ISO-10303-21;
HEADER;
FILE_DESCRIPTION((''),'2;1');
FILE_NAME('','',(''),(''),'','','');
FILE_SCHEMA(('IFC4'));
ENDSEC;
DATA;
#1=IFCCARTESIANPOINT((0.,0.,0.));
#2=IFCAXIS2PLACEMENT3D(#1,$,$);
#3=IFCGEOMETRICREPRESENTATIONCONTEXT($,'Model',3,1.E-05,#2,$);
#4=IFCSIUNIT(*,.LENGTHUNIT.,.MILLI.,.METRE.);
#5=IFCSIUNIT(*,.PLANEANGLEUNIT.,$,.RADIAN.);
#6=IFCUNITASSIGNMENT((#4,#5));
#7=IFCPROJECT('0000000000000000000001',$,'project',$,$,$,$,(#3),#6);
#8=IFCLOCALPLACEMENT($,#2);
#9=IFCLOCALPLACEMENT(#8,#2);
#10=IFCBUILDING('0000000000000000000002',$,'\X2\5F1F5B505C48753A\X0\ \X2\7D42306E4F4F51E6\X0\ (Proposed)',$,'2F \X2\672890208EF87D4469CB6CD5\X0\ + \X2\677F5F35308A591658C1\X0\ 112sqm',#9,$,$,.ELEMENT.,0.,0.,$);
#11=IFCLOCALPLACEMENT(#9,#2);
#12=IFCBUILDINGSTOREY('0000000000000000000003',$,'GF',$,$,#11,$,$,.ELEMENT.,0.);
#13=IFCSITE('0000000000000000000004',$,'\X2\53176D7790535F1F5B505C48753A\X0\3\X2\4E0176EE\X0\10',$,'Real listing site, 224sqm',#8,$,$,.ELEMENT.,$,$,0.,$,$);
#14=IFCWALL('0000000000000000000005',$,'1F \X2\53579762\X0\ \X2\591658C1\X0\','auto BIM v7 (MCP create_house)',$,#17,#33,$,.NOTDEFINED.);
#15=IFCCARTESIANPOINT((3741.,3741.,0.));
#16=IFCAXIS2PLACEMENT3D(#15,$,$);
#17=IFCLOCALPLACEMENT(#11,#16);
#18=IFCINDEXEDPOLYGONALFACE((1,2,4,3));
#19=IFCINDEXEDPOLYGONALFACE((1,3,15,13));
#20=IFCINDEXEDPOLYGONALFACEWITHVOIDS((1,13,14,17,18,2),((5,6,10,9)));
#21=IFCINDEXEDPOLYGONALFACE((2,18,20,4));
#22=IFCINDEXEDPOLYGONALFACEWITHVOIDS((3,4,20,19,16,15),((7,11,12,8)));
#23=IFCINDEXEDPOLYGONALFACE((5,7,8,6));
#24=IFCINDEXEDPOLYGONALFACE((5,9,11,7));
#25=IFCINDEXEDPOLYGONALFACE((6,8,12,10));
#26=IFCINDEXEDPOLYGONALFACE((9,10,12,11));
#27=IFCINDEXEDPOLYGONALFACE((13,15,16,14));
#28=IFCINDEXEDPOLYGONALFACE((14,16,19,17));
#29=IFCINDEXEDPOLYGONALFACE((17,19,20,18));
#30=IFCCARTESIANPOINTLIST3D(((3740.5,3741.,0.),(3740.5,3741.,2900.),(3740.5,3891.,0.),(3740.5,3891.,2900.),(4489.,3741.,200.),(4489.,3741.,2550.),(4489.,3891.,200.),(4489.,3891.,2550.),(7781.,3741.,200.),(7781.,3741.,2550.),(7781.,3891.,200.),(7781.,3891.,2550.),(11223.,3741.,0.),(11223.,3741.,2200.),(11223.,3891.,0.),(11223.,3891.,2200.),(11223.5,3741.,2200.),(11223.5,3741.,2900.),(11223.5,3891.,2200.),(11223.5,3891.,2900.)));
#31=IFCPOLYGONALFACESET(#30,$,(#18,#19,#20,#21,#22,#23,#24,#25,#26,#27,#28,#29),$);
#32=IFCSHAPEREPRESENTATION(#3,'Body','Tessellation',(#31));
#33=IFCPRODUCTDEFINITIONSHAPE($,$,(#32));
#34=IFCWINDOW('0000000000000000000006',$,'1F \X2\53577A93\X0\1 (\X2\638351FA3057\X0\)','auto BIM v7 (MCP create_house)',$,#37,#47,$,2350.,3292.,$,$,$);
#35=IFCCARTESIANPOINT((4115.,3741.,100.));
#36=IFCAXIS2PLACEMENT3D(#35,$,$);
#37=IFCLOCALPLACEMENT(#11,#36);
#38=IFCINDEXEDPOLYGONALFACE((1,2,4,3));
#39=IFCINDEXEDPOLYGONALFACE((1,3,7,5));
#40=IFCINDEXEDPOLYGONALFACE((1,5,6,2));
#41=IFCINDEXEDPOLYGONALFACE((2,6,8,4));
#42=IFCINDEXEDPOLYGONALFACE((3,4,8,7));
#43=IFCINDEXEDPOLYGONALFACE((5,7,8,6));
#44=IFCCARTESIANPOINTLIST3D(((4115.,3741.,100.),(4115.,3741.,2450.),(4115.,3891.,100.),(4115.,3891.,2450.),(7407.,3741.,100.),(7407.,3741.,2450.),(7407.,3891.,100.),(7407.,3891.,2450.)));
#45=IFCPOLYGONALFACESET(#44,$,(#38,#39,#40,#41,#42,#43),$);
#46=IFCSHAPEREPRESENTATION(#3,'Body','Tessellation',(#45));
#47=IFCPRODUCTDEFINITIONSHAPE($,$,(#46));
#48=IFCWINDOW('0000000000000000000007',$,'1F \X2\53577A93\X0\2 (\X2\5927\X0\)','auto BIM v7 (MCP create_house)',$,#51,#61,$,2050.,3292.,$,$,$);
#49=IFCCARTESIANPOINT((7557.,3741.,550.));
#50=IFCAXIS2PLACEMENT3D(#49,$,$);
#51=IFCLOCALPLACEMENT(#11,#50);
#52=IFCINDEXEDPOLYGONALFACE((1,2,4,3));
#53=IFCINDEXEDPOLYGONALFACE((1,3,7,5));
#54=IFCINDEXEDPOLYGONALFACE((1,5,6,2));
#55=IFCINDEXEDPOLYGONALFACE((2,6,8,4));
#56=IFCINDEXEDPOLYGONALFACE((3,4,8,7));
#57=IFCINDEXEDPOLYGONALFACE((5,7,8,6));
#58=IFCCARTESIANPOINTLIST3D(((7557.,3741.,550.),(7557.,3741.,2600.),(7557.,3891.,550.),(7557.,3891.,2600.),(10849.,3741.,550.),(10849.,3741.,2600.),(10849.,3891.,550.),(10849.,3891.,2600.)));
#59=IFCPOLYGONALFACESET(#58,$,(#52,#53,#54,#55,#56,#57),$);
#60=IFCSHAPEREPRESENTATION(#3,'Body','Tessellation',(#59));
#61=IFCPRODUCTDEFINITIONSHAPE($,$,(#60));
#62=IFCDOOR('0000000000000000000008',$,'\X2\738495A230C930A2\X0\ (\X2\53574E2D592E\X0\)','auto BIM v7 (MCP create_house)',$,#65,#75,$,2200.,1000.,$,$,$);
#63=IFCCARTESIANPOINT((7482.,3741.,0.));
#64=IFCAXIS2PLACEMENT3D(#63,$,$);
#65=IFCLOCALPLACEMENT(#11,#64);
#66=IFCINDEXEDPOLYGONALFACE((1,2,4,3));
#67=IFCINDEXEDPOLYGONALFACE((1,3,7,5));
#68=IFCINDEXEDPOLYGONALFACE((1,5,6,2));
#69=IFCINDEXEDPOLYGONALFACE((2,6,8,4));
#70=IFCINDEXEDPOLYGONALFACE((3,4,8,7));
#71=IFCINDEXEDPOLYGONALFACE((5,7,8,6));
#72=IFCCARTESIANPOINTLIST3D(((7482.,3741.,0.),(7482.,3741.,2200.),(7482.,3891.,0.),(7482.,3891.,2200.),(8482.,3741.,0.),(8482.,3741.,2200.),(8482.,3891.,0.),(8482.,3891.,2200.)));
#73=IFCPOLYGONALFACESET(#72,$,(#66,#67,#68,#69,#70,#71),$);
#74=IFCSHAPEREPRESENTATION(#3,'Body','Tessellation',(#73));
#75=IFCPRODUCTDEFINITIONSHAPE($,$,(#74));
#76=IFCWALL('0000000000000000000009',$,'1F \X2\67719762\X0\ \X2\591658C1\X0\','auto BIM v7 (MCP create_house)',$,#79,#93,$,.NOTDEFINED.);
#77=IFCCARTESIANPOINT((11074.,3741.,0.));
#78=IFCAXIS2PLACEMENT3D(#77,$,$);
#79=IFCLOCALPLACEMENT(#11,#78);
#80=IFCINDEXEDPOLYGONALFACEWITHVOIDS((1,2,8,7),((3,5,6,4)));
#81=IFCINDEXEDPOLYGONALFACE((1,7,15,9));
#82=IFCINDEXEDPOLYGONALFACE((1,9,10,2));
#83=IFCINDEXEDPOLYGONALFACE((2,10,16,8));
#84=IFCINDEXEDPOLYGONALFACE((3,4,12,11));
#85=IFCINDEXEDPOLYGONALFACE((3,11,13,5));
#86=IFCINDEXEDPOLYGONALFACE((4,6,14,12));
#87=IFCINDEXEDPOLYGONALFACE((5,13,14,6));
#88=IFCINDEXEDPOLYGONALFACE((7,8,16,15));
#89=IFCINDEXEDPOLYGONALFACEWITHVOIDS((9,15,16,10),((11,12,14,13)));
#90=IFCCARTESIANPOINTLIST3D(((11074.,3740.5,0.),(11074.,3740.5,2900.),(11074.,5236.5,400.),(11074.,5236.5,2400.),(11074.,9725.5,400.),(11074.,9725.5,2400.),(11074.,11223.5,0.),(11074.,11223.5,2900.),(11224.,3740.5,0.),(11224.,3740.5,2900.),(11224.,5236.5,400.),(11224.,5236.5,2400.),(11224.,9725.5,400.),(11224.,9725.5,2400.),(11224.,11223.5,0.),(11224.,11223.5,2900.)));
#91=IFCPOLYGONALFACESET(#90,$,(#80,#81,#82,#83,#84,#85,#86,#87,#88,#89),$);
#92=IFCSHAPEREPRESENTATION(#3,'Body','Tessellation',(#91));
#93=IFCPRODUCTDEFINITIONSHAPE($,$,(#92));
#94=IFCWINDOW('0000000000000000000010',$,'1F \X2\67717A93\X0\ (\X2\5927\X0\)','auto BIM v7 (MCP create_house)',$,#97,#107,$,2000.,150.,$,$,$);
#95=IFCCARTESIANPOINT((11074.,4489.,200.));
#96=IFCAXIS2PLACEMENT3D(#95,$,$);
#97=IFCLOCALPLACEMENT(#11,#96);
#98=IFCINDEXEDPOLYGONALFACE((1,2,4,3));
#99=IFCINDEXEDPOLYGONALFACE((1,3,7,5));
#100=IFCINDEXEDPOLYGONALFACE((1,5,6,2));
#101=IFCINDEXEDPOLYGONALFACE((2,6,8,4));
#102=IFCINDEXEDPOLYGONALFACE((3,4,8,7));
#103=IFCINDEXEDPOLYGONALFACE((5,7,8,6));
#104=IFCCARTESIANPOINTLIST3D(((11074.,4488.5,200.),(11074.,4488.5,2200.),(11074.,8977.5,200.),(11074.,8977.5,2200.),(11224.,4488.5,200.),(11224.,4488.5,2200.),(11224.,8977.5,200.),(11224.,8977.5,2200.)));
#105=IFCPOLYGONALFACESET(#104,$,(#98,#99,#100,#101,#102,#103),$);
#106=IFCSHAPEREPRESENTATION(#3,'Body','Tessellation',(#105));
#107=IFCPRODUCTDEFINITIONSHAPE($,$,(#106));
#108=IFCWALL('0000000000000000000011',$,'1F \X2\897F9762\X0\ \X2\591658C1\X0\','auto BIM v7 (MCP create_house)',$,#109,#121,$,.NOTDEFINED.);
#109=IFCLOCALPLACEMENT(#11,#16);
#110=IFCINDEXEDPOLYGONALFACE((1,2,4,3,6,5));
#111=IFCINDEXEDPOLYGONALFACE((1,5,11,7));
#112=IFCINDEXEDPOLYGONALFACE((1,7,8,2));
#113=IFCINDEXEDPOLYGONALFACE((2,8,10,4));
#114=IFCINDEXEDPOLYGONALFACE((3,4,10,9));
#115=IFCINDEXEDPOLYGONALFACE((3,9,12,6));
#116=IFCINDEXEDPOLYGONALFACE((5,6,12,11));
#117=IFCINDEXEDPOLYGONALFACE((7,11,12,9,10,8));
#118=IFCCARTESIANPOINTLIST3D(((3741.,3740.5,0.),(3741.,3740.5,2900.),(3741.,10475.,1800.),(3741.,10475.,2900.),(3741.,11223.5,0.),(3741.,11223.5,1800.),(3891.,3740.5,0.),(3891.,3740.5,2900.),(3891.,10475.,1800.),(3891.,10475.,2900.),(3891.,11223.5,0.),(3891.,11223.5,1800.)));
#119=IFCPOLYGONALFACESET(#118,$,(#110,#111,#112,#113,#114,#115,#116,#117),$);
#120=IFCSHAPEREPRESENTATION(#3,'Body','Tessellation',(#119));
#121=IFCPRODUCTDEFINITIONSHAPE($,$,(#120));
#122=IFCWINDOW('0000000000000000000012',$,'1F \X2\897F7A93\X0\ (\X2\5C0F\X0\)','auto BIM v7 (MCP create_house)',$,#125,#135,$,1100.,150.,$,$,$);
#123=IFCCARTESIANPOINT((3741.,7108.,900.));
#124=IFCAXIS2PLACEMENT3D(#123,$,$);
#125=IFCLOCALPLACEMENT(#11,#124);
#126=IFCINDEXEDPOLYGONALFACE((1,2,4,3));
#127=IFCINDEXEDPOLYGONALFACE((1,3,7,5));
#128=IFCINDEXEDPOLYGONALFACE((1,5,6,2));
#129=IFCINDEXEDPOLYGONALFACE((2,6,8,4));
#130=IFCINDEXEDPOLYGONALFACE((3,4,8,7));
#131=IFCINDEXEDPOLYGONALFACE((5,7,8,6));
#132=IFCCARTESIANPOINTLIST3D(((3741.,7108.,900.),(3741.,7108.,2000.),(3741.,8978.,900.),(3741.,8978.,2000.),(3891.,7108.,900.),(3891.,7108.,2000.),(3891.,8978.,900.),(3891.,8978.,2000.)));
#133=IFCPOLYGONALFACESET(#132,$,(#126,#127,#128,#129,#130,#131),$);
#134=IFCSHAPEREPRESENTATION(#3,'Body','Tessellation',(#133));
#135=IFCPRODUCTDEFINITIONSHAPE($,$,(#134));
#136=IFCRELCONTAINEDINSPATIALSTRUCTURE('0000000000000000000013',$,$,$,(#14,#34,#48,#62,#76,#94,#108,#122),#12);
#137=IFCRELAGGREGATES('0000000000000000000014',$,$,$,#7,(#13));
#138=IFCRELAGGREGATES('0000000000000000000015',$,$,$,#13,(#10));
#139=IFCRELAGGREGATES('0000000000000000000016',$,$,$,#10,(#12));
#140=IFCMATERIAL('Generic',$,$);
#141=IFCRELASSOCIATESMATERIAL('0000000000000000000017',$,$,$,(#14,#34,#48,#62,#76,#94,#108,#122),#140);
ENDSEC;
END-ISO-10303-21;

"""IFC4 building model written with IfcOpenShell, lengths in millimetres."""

from ifc_helpers import new_model, si_unit, frame, frame_2d, origin, place, context, project, spatial, rectangle, extrude, material, element, fill, save


model = new_model("IFC4")

# Units and contexts
model_context = context("Model", 3, precision=1e-05, world=origin())
ifc_project = project(units=[si_unit("LENGTHUNIT", "METRE", prefix="MILLI"), si_unit("PLANEANGLEUNIT", "RADIAN")], contexts=[model_context])

# Site, building, storey
site_placement = place(None, origin())
site = spatial("IfcSite", under=ifc_project, at=site_placement, Name="北海道弟子屈町3丁目10", ObjectType="Real listing site, 224sqm", CompositionType="ELEMENT", RefElevation=0.0)
building_placement = place(site_placement, origin())
building = spatial("IfcBuilding", under=site, at=building_placement, Name="弟子屈町 終の住処 (Proposed)", ObjectType="2F 木造軸組構法 + 板張り外壁 112sqm", CompositionType="ELEMENT", ElevationOfRefHeight=0.0, ElevationOfTerrain=0.0)
storey_placement = place(building_placement, origin())
storey = spatial("IfcBuildingStorey", under=building, at=storey_placement, Name="GF", CompositionType="ELEMENT", Elevation=0.0)

# Shared definitions
ifc_material = material(Name="Generic")

# Wall, openings, windows, door
wall_1_placement = place(storey_placement, frame((3741.0, 3741.0, 0.0)))
wall_1 = element("IfcWall", 1, at=wall_1_placement, inside=storey, material=ifc_material, Name="1F 南面 外壁", Description="auto BIM v7 (MCP create_house)", PredefinedType="NOTDEFINED", context=model_context, shape_type="SweptSolid", body=[
    extrude(rectangle(XDim=7483.0, YDim=150.0, at=frame_2d((3741.0, 75.0))), frame((3741.0, 3741.0, 0.0)), (0.0, 0.0, 1.0), 2900.0),
])
opening_1_placement = place(storey_placement, frame((4115.0, 3741.0, 100.0)))
opening_1 = element("IfcOpeningElement", 2, at=opening_1_placement, cuts=wall_1, PredefinedType="NOTDEFINED", context=model_context, shape_type="SweptSolid", body=[
    extrude(rectangle(XDim=3292.0, YDim=150.0, at=frame_2d((1646.0, 75.0))), frame((4115.0, 3741.0, 100.0)), (0.0, 0.0, 1.0), 2350.0),
])
opening_2_placement = place(storey_placement, frame((7557.0, 3741.0, 550.0)))
opening_2 = element("IfcOpeningElement", 3, at=opening_2_placement, cuts=wall_1, PredefinedType="NOTDEFINED", context=model_context, shape_type="SweptSolid", body=[
    extrude(rectangle(XDim=3292.0, YDim=150.0, at=frame_2d((1646.0, 75.0))), frame((7557.0, 3741.0, 550.0)), (0.0, 0.0, 1.0), 2050.0),
])
opening_3_placement = place(storey_placement, frame((7482.0, 3741.0, 0.0)))
opening_3 = element("IfcOpeningElement", 4, at=opening_3_placement, cuts=wall_1, PredefinedType="NOTDEFINED", context=model_context, shape_type="SweptSolid", body=[
    extrude(rectangle(XDim=1000.0, YDim=150.0, at=frame_2d((500.0, 75.0))), frame((7482.0, 3741.0, 0.0)), (0.0, 0.0, 1.0), 2200.0),
])
window_1_placement = place(storey_placement, frame((4115.0, 3741.0, 100.0)))
window_1 = element("IfcWindow", 5, at=window_1_placement, inside=storey, material=ifc_material, Name="1F 南窓1 (掃出し)", Description="auto BIM v7 (MCP create_house)", OverallHeight=2350.0, OverallWidth=3292.0, context=model_context, shape_type="SweptSolid", body=[
    extrude(rectangle(XDim=3292.0, YDim=150.0, at=frame_2d((1646.0, 75.0))), frame((4115.0, 3741.0, 100.0)), (0.0, 0.0, 1.0), 2350.0),
])
fill(opening_1, window_1)
window_2_placement = place(storey_placement, frame((7557.0, 3741.0, 550.0)))
window_2 = element("IfcWindow", 6, at=window_2_placement, inside=storey, material=ifc_material, Name="1F 南窓2 (大)", Description="auto BIM v7 (MCP create_house)", OverallHeight=2050.0, OverallWidth=3292.0, context=model_context, shape_type="SweptSolid", body=[
    extrude(rectangle(XDim=3292.0, YDim=150.0, at=frame_2d((1646.0, 75.0))), frame((7557.0, 3741.0, 550.0)), (0.0, 0.0, 1.0), 2050.0),
])
fill(opening_2, window_2)
door_placement = place(storey_placement, frame((7482.0, 3741.0, 0.0)))
door = element("IfcDoor", 7, at=door_placement, inside=storey, material=ifc_material, Name="玄関ドア (南中央)", Description="auto BIM v7 (MCP create_house)", OverallHeight=2200.0, OverallWidth=1000.0, context=model_context, shape_type="SweptSolid", body=[
    extrude(rectangle(XDim=1000.0, YDim=150.0, at=frame_2d((500.0, 75.0))), frame((7482.0, 3741.0, 0.0)), (0.0, 0.0, 1.0), 2200.0),
])
fill(opening_3, door)

# Walls, openings, windows
wall_2_placement = place(storey_placement, frame((11074.0, 3741.0, 0.0)))
wall_2 = element("IfcWall", 8, at=wall_2_placement, inside=storey, material=ifc_material, Name="1F 東面 外壁", Description="auto BIM v7 (MCP create_house)", PredefinedType="NOTDEFINED", context=model_context, shape_type="SweptSolid", body=[
    extrude(rectangle(XDim=150.0, YDim=7483.0, at=frame_2d((75.0, 3741.0))), frame((11074.0, 3741.0, 0.0)), (0.0, 0.0, 1.0), 2900.0),
])
opening_4_placement = place(storey_placement, frame((11074.0, 4489.0, 200.0)))
opening_4 = element("IfcOpeningElement", 9, at=opening_4_placement, cuts=wall_2, PredefinedType="NOTDEFINED", context=model_context, shape_type="SweptSolid", body=[
    extrude(rectangle(XDim=150.0, YDim=4489.0, at=frame_2d((75.0, 2244.0))), frame((11074.0, 4489.0, 200.0)), (0.0, 0.0, 1.0), 2000.0),
])
window_3_placement = place(storey_placement, frame((11074.0, 4489.0, 200.0)))
window_3 = element("IfcWindow", 10, at=window_3_placement, inside=storey, material=ifc_material, Name="1F 東窓 (大)", Description="auto BIM v7 (MCP create_house)", OverallHeight=2000.0, OverallWidth=150.0, context=model_context, shape_type="SweptSolid", body=[
    extrude(rectangle(XDim=150.0, YDim=4489.0, at=frame_2d((75.0, 2244.0))), frame((11074.0, 4489.0, 200.0)), (0.0, 0.0, 1.0), 2000.0),
])
fill(opening_4, window_3)
wall_3_placement = place(storey_placement, frame((3741.0, 3741.0, 0.0)))
wall_3 = element("IfcWall", 11, at=wall_3_placement, inside=storey, material=ifc_material, Name="1F 西面 外壁", Description="auto BIM v7 (MCP create_house)", PredefinedType="NOTDEFINED", context=model_context, shape_type="SweptSolid", body=[
    extrude(rectangle(XDim=150.0, YDim=7483.0, at=frame_2d((75.0, 3741.0))), frame((3741.0, 3741.0, 0.0)), (0.0, 0.0, 1.0), 2900.0),
])
opening_5_placement = place(storey_placement, frame((3741.0, 7108.0, 900.0)))
opening_5 = element("IfcOpeningElement", 12, at=opening_5_placement, cuts=wall_3, PredefinedType="NOTDEFINED", context=model_context, shape_type="SweptSolid", body=[
    extrude(rectangle(XDim=150.0, YDim=1870.0, at=frame_2d((75.0, 935.0))), frame((3741.0, 7108.0, 900.0)), (0.0, 0.0, 1.0), 1100.0),
])
window_4_placement = place(storey_placement, frame((3741.0, 7108.0, 900.0)))
window_4 = element("IfcWindow", 13, at=window_4_placement, inside=storey, material=ifc_material, Name="1F 西窓 (小)", Description="auto BIM v7 (MCP create_house)", OverallHeight=1100.0, OverallWidth=150.0, context=model_context, shape_type="SweptSolid", body=[
    extrude(rectangle(XDim=150.0, YDim=1870.0, at=frame_2d((75.0, 935.0))), frame((3741.0, 7108.0, 900.0)), (0.0, 0.0, 1.0), 1100.0),
])
fill(opening_5, window_4)

save(model, "model.ifc")
